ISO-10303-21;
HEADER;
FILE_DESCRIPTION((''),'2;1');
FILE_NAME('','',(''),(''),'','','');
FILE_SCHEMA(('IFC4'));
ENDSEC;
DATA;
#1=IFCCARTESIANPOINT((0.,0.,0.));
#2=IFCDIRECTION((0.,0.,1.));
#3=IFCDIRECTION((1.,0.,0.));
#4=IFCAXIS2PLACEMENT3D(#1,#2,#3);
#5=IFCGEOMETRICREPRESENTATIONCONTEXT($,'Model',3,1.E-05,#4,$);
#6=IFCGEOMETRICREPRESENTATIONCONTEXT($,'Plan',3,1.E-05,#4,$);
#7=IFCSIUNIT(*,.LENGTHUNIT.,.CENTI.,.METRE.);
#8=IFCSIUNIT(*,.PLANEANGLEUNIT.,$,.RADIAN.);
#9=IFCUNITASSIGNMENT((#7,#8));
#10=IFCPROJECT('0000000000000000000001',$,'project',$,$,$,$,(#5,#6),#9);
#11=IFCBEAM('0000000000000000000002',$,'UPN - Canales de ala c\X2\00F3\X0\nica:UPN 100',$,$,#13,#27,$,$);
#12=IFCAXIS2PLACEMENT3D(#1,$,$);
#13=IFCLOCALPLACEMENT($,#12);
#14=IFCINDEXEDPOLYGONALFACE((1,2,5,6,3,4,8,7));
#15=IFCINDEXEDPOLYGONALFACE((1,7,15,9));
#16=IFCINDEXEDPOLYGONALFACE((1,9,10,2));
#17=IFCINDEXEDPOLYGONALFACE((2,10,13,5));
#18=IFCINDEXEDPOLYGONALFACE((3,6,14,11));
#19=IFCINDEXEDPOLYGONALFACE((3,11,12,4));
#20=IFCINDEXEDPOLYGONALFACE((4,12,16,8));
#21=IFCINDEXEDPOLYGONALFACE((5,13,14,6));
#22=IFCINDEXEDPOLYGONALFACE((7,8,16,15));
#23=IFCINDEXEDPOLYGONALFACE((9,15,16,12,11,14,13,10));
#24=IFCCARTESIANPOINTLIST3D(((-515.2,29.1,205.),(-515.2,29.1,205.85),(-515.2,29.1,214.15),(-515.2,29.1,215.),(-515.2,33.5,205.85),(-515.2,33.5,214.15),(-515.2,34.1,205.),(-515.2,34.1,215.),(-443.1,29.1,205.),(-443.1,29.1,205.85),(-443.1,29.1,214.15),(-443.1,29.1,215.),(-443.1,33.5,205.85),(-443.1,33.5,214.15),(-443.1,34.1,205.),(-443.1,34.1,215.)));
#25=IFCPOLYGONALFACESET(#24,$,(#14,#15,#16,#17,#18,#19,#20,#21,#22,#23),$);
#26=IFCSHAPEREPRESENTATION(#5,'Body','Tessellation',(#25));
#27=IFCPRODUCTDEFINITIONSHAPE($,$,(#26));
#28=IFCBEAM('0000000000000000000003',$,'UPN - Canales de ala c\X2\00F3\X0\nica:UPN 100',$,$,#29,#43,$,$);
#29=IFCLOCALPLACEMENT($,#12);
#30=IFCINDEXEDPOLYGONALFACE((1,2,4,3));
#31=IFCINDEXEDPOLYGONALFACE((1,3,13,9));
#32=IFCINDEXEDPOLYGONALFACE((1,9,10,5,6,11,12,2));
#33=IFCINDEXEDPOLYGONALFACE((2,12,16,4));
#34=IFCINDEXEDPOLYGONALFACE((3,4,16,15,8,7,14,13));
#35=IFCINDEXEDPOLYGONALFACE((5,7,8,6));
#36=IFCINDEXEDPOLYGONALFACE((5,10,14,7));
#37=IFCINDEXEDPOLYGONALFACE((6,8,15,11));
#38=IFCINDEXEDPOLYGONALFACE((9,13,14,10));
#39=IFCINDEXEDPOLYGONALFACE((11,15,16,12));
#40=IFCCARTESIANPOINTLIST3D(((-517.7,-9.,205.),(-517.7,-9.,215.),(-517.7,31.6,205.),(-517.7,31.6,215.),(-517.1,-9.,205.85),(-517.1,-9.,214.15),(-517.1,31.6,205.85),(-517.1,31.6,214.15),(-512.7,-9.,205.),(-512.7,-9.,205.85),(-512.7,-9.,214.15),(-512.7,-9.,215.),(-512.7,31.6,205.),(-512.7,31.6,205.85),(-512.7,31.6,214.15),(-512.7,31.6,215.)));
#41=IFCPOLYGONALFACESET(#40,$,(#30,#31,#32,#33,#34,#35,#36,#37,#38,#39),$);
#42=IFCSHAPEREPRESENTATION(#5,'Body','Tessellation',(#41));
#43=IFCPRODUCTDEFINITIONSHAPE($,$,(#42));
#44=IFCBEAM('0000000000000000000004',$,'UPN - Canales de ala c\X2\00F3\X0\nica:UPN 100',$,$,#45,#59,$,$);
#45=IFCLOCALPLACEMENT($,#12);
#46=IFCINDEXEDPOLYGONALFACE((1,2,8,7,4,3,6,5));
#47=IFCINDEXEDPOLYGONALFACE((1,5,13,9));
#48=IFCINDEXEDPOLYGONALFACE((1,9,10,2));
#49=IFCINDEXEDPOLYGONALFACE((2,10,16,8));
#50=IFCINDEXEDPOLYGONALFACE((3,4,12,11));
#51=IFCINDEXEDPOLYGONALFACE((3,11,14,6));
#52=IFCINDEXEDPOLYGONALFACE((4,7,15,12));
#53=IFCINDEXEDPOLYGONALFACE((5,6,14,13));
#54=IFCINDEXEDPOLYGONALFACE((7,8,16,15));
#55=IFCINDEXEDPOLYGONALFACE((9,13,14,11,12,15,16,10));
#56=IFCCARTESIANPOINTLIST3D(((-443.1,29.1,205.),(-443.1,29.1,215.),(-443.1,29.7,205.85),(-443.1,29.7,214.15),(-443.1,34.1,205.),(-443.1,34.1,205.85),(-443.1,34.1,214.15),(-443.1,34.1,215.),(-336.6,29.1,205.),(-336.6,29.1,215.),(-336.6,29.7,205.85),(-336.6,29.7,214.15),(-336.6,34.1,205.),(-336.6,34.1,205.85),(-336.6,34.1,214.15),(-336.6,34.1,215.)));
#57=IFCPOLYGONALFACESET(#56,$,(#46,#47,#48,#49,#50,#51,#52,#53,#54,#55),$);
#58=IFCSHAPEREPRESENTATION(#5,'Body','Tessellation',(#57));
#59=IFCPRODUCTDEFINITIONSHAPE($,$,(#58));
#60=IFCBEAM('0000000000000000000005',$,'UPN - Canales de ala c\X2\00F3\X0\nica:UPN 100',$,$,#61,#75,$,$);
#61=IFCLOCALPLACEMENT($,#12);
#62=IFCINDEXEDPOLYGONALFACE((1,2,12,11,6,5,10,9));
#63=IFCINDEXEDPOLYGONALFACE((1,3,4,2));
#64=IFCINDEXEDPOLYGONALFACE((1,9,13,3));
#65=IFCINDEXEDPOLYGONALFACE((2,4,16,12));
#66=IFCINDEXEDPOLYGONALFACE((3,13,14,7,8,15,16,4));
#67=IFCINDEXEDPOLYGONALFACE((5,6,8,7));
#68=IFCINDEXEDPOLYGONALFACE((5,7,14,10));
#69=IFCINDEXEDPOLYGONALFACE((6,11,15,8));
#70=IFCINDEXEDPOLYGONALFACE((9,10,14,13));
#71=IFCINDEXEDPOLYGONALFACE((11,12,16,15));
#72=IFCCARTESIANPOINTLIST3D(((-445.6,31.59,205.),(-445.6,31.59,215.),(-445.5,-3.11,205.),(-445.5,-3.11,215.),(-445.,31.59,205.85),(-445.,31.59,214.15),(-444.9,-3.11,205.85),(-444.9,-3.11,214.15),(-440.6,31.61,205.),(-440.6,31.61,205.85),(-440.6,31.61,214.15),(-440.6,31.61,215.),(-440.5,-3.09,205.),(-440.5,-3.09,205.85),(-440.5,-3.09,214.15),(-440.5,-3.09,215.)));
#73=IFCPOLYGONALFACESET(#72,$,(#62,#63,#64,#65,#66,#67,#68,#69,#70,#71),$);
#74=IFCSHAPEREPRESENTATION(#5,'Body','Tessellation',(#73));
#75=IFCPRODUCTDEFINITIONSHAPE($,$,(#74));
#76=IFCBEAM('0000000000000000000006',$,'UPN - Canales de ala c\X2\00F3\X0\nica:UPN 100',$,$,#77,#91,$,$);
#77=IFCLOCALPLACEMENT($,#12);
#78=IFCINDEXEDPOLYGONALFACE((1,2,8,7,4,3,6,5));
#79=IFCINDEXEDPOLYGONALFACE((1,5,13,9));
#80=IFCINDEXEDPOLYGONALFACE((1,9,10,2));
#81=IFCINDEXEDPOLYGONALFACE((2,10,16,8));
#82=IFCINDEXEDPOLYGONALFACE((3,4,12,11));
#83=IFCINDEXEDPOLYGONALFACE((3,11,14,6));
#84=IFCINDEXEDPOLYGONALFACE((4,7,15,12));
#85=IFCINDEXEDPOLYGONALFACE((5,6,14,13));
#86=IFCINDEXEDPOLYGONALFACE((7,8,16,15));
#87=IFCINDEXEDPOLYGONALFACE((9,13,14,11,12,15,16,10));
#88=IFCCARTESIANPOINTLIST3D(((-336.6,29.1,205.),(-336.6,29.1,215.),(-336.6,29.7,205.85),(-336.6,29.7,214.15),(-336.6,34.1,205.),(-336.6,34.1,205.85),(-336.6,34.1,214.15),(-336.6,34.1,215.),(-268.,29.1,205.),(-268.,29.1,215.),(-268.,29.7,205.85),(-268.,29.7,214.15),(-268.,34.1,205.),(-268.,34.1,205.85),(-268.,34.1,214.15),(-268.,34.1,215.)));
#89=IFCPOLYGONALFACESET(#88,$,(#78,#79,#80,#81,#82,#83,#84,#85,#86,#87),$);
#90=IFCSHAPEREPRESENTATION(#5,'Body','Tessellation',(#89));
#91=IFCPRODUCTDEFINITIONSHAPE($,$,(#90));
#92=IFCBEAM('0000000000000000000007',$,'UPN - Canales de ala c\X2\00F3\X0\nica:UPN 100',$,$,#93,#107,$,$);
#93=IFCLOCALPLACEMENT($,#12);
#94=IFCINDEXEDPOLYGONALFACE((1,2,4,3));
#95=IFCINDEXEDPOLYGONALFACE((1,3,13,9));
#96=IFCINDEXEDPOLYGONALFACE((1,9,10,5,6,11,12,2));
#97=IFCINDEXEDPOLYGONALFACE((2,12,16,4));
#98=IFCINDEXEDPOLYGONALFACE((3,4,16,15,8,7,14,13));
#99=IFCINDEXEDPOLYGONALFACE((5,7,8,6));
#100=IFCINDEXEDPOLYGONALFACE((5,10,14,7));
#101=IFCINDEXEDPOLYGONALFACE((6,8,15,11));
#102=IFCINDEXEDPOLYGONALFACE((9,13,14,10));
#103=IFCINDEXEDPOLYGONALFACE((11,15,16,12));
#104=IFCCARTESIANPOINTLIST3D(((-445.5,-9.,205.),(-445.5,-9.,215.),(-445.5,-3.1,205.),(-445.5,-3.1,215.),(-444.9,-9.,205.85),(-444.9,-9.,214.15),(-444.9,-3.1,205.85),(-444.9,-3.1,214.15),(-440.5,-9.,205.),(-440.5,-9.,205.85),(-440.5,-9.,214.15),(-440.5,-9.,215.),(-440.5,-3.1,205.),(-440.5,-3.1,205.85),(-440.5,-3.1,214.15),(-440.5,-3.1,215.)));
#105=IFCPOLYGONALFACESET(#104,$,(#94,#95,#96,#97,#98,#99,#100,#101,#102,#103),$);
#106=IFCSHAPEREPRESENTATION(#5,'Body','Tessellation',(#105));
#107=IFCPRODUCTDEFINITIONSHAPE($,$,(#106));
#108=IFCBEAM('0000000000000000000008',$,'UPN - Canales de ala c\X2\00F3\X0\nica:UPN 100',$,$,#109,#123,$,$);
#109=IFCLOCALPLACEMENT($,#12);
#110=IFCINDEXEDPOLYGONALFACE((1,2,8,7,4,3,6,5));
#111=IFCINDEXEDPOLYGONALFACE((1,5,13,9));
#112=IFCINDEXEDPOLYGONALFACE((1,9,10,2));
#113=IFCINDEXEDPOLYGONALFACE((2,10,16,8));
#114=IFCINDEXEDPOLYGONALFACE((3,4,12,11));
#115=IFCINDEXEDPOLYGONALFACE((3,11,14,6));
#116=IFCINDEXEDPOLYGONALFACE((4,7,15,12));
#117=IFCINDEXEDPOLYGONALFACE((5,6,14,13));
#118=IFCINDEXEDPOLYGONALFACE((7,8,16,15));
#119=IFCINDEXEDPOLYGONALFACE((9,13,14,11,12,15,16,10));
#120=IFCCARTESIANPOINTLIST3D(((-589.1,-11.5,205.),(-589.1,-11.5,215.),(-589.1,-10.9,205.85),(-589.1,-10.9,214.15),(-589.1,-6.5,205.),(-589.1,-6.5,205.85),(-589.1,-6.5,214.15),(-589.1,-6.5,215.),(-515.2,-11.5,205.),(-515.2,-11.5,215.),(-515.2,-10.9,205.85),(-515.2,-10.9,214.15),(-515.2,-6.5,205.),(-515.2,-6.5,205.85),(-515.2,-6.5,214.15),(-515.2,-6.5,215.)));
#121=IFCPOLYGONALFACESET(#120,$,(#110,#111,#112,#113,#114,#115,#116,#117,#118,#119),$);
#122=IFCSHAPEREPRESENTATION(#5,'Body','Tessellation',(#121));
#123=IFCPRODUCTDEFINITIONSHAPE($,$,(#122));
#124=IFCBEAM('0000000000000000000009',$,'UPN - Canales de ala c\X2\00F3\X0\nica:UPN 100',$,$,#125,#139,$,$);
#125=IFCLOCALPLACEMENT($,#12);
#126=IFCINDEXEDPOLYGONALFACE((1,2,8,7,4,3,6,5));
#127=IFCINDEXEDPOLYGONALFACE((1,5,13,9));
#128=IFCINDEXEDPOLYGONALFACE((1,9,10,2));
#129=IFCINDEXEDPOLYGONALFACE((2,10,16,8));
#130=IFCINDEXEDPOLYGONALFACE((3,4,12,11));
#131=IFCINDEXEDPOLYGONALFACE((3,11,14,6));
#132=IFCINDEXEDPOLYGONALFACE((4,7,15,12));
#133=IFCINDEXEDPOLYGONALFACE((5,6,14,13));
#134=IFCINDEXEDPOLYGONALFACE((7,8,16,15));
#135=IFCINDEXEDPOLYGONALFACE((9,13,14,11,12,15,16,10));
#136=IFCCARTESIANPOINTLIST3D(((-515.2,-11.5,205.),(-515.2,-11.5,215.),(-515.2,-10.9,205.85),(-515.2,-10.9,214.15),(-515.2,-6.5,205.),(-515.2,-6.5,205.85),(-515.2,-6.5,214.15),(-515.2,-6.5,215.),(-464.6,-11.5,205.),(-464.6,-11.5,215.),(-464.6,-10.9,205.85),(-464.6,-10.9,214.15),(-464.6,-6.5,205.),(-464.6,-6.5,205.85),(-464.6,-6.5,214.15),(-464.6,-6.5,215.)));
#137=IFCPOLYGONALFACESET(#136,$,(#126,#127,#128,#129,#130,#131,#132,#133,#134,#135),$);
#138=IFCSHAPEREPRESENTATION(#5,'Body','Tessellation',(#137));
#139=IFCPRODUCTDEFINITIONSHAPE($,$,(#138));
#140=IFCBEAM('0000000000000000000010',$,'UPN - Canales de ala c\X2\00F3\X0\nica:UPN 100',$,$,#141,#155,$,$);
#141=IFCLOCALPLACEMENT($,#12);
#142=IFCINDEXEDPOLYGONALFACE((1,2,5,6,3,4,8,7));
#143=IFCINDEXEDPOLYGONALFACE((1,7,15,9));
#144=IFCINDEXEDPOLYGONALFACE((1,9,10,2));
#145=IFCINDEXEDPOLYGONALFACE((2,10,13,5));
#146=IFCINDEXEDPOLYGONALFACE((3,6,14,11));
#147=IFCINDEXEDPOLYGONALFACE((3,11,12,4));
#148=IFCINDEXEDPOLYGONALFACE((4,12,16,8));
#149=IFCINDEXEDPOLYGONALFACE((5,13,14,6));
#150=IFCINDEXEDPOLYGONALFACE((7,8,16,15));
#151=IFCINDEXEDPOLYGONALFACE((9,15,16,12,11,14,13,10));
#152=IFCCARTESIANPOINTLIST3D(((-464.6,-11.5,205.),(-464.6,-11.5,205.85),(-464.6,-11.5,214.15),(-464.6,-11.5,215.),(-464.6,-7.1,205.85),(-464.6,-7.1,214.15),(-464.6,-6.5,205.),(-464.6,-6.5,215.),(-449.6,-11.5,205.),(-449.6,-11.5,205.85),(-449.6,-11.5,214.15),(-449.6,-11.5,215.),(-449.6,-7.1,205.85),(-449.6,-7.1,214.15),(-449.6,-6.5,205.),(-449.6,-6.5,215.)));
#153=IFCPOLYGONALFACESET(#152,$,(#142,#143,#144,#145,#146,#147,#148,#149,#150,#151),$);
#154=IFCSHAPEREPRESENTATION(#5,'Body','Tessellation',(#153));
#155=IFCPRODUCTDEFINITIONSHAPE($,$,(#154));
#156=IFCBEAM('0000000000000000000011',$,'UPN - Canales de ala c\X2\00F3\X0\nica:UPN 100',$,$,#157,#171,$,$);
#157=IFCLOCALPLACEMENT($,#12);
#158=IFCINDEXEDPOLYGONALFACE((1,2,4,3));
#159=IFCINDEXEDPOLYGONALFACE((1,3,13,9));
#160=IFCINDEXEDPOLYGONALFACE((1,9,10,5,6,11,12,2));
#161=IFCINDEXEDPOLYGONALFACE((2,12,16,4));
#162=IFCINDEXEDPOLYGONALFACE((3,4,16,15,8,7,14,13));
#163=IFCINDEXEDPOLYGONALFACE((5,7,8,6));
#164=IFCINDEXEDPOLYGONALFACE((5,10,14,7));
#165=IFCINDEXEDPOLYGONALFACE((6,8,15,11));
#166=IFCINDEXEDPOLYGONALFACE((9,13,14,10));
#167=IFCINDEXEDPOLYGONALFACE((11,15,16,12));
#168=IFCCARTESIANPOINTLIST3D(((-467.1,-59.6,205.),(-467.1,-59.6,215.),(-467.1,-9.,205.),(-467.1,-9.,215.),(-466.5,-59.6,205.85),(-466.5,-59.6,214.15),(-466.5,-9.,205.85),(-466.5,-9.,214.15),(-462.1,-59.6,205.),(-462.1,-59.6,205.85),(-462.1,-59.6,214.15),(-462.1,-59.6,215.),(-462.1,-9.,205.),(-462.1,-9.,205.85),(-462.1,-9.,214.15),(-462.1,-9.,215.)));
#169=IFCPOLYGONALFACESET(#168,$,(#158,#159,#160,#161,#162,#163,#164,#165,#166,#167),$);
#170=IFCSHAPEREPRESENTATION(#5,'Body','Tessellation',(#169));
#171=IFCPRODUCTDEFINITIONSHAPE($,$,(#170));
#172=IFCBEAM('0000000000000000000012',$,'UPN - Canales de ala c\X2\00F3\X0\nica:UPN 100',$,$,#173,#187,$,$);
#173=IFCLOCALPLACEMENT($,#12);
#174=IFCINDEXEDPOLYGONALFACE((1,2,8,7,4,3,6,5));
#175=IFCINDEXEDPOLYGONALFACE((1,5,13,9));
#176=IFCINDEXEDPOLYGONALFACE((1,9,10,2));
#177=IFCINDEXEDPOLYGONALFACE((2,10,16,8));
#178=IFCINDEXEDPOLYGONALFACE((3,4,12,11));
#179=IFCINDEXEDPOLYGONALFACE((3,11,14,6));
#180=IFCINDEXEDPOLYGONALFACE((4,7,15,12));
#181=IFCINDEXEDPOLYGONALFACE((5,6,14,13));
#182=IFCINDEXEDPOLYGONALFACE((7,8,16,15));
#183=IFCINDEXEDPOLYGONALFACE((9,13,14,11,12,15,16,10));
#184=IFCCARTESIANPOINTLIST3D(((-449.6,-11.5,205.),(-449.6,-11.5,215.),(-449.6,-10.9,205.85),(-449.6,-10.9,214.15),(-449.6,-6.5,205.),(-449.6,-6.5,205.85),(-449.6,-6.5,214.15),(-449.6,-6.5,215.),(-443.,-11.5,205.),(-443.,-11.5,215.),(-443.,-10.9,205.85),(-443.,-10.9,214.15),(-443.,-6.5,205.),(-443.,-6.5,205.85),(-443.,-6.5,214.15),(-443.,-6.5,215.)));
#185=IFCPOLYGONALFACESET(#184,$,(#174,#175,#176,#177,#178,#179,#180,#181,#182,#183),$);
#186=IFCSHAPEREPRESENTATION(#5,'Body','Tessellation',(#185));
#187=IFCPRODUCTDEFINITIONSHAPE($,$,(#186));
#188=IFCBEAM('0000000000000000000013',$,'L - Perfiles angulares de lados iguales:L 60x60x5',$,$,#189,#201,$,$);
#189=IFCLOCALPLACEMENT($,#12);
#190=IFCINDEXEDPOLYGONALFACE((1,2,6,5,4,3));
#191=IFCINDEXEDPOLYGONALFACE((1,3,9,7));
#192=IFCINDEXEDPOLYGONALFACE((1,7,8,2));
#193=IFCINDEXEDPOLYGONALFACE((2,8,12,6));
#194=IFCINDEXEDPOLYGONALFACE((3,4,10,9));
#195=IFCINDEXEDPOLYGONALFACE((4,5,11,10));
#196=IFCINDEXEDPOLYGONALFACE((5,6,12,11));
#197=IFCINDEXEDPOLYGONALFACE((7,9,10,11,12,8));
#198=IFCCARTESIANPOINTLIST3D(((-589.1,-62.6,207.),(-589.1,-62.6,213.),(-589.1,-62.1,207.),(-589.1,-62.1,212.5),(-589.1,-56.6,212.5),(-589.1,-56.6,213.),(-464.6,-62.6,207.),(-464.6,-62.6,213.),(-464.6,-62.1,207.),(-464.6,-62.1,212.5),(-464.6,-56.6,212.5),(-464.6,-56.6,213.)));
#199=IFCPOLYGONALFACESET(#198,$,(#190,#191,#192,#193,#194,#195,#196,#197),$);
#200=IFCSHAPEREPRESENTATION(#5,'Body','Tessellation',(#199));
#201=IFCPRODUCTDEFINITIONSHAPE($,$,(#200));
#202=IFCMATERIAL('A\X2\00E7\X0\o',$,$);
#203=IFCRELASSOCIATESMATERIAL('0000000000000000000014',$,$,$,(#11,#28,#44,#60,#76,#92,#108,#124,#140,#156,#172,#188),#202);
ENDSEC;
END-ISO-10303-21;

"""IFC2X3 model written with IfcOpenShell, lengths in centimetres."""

from ifc_helpers import new_model, si_unit, frame, frame_2d, origin_with_axes, origin_2d_with_axis, place, context, project, polyline, u_section, outline, extrude, material, element, save


model = new_model("IFC2X3")

# Units and contexts
model_context = context("Model", 3, precision=1e-05, world=origin_with_axes())
plan_context = context("Plan", 3, precision=1e-05, world=origin_with_axes())
ifc_project = project(units=[si_unit("LENGTHUNIT", "METRE", prefix="CENTI"), si_unit("PLANEANGLEUNIT", "RADIAN")], contexts=[model_context, plan_context])

# Shared definitions
ifc_material = material(Name="Aço")

# Beams
beam_1_placement = place(None, frame((-443.1, 31.6, 210.0), z_axis=(-1.0, 0.0, 0.0), x_axis=(0.0, -1.0, 0.0)))
element("IfcBeam", 1, at=beam_1_placement, material=ifc_material, Name="UPN - Canales de ala cónica:UPN 100", context=model_context, shape_type="SweptSolid", body=[
    extrude(u_section(Depth=10.0, FlangeWidth=5.0, WebThickness=0.6, FlangeThickness=0.85, FilletRadius=0.0, EdgeRadius=0.0, FlangeSlope=0.0, CentreOfGravityInX=0.0, at=frame_2d((0.0, 0.0), x_axis=(1.0, 0.0))), origin_with_axes(), (0.0, 0.0, 1.0), 72.1),
])
beam_2_placement = place(None, frame((-515.2, -9.0, 210.0), z_axis=(0.0, 1.0, 0.0), x_axis=(1.0, 0.0, 0.0)))
element("IfcBeam", 2, at=beam_2_placement, material=ifc_material, Name="UPN - Canales de ala cónica:UPN 100", context=model_context, shape_type="SweptSolid", body=[
    extrude(u_section(Depth=10.0, FlangeWidth=5.0, WebThickness=0.6, FlangeThickness=0.85, FilletRadius=0.0, EdgeRadius=0.0, FlangeSlope=0.0, CentreOfGravityInX=0.0, at=origin_2d_with_axis()), origin_with_axes(), (0.0, 0.0, 1.0), 40.6),
])
beam_3_placement = place(None, frame((-336.6, 31.6, 210.0), z_axis=(-1.0, 0.0, 0.0), x_axis=(0.0, 1.0, 0.0)))
element("IfcBeam", 3, at=beam_3_placement, material=ifc_material, Name="UPN - Canales de ala cónica:UPN 100", context=model_context, shape_type="SweptSolid", body=[
    extrude(u_section(Depth=10.0, FlangeWidth=5.0, WebThickness=0.6, FlangeThickness=0.85, FilletRadius=0.0, EdgeRadius=0.0, FlangeSlope=0.0, CentreOfGravityInX=0.0, at=frame_2d((0.0, 0.0), x_axis=(1.0, 0.0))), origin_with_axes(), (0.0, 0.0, 1.0), 106.5),
])
beam_4_placement = place(None, frame((-443.0, -3.1, 210.0), z_axis=(-0.002882, 0.999996, 0.0), x_axis=(0.999996, 0.002882, 0.0)))
element("IfcBeam", 4, at=beam_4_placement, material=ifc_material, Name="UPN - Canales de ala cónica:UPN 100", context=model_context, shape_type="SweptSolid", body=[
    extrude(u_section(Depth=10.0, FlangeWidth=5.0, WebThickness=0.6, FlangeThickness=0.85, FilletRadius=0.0, EdgeRadius=0.0, FlangeSlope=0.0, CentreOfGravityInX=0.0, at=frame_2d((0.0, 0.0), x_axis=(1.0, 0.0))), origin_with_axes(), (0.0, 0.0, 1.0), 34.7),
])
beam_5_placement = place(None, frame((-268.0, 31.6, 210.0), z_axis=(-1.0, 0.0, 0.0), x_axis=(0.0, 1.0, 0.0)))
element("IfcBeam", 5, at=beam_5_placement, material=ifc_material, Name="UPN - Canales de ala cónica:UPN 100", context=model_context, shape_type="SweptSolid", body=[
    extrude(u_section(Depth=10.0, FlangeWidth=5.0, WebThickness=0.6, FlangeThickness=0.85, FilletRadius=0.0, EdgeRadius=0.0, FlangeSlope=0.0, CentreOfGravityInX=0.0, at=frame_2d((0.0, 0.0), x_axis=(1.0, 0.0))), origin_with_axes(), (0.0, 0.0, 1.0), 68.6),
])
beam_6_placement = place(None, frame((-443.0, -9.0, 210.0), z_axis=(0.0, 1.0, 0.0), x_axis=(1.0, 0.0, 0.0)))
element("IfcBeam", 6, at=beam_6_placement, material=ifc_material, Name="UPN - Canales de ala cónica:UPN 100", context=model_context, shape_type="SweptSolid", body=[
    extrude(u_section(Depth=10.0, FlangeWidth=5.0, WebThickness=0.6, FlangeThickness=0.85, FilletRadius=0.0, EdgeRadius=0.0, FlangeSlope=0.0, CentreOfGravityInX=0.0, at=origin_2d_with_axis()), origin_with_axes(), (0.0, 0.0, 1.0), 5.9),
])
beam_7_placement = place(None, frame((-515.2, -9.0, 210.0), z_axis=(-1.0, 0.0, 0.0), x_axis=(0.0, 1.0, 0.0)))
element("IfcBeam", 7, at=beam_7_placement, material=ifc_material, Name="UPN - Canales de ala cónica:UPN 100", context=model_context, shape_type="SweptSolid", body=[
    extrude(u_section(Depth=10.0, FlangeWidth=5.0, WebThickness=0.6, FlangeThickness=0.85, FilletRadius=0.0, EdgeRadius=0.0, FlangeSlope=0.0, CentreOfGravityInX=0.0, at=frame_2d((0.0, 0.0), x_axis=(1.0, 0.0))), origin_with_axes(), (0.0, 0.0, 1.0), 73.9),
])
beam_8_placement = place(None, frame((-464.6, -9.0, 210.0), z_axis=(-1.0, 0.0, 0.0), x_axis=(0.0, 1.0, 0.0)))
element("IfcBeam", 8, at=beam_8_placement, material=ifc_material, Name="UPN - Canales de ala cónica:UPN 100", context=model_context, shape_type="SweptSolid", body=[
    extrude(u_section(Depth=10.0, FlangeWidth=5.0, WebThickness=0.6, FlangeThickness=0.85, FilletRadius=0.0, EdgeRadius=0.0, FlangeSlope=0.0, CentreOfGravityInX=0.0, at=frame_2d((0.0, 0.0), x_axis=(1.0, 0.0))), origin_with_axes(), (0.0, 0.0, 1.0), 50.6),
])
beam_9_placement = place(None, frame((-449.6, -9.0, 210.0), z_axis=(-1.0, 0.0, 0.0), x_axis=(0.0, -1.0, 0.0)))
element("IfcBeam", 9, at=beam_9_placement, material=ifc_material, Name="UPN - Canales de ala cónica:UPN 100", context=model_context, shape_type="SweptSolid", body=[
    extrude(u_section(Depth=10.0, FlangeWidth=5.0, WebThickness=0.6, FlangeThickness=0.85, FilletRadius=0.0, EdgeRadius=0.0, FlangeSlope=0.0, CentreOfGravityInX=0.0, at=origin_2d_with_axis()), origin_with_axes(), (0.0, 0.0, 1.0), 15.0),
])
beam_10_placement = place(None, frame((-464.6, -59.6, 210.0), z_axis=(0.0, 1.0, 0.0), x_axis=(1.0, 0.0, 0.0)))
element("IfcBeam", 10, at=beam_10_placement, material=ifc_material, Name="UPN - Canales de ala cónica:UPN 100", context=model_context, shape_type="SweptSolid", body=[
    extrude(u_section(Depth=10.0, FlangeWidth=5.0, WebThickness=0.6, FlangeThickness=0.85, FilletRadius=0.0, EdgeRadius=0.0, FlangeSlope=0.0, CentreOfGravityInX=0.0, at=origin_2d_with_axis()), origin_with_axes(), (0.0, 0.0, 1.0), 50.6),
])
beam_11_placement = place(None, frame((-443.0, -9.0, 210.0), z_axis=(-1.0, 0.0, 0.0), x_axis=(0.0, 1.0, 0.0)))
element("IfcBeam", 11, at=beam_11_placement, material=ifc_material, Name="UPN - Canales de ala cónica:UPN 100", context=model_context, shape_type="SweptSolid", body=[
    extrude(u_section(Depth=10.0, FlangeWidth=5.0, WebThickness=0.6, FlangeThickness=0.85, FilletRadius=0.0, EdgeRadius=0.0, FlangeSlope=0.0, CentreOfGravityInX=0.0, at=frame_2d((0.0, 0.0), x_axis=(1.0, 0.0))), origin_with_axes(), (0.0, 0.0, 1.0), 6.6),
])
beam_12_placement = place(None, frame((-464.6, -59.6, 210.0), z_axis=(-1.0, 0.0, 0.0), x_axis=(0.0, -1.0, 0.0)))
element("IfcBeam", 12, at=beam_12_placement, material=ifc_material, Name="L - Perfiles angulares de lados iguales:L 60x60x5", context=model_context, shape_type="SweptSolid", body=[
    extrude(outline(polyline([(3.0, -3.0), (3.0, 3.0), (-3.0, 3.0), (-3.0, 2.5), (2.5, 2.5), (2.5, -3.0), (3.0, -3.0)])), origin_with_axes(), (0.0, 0.0, 1.0), 124.5),
])

save(model, "model.ifc")
